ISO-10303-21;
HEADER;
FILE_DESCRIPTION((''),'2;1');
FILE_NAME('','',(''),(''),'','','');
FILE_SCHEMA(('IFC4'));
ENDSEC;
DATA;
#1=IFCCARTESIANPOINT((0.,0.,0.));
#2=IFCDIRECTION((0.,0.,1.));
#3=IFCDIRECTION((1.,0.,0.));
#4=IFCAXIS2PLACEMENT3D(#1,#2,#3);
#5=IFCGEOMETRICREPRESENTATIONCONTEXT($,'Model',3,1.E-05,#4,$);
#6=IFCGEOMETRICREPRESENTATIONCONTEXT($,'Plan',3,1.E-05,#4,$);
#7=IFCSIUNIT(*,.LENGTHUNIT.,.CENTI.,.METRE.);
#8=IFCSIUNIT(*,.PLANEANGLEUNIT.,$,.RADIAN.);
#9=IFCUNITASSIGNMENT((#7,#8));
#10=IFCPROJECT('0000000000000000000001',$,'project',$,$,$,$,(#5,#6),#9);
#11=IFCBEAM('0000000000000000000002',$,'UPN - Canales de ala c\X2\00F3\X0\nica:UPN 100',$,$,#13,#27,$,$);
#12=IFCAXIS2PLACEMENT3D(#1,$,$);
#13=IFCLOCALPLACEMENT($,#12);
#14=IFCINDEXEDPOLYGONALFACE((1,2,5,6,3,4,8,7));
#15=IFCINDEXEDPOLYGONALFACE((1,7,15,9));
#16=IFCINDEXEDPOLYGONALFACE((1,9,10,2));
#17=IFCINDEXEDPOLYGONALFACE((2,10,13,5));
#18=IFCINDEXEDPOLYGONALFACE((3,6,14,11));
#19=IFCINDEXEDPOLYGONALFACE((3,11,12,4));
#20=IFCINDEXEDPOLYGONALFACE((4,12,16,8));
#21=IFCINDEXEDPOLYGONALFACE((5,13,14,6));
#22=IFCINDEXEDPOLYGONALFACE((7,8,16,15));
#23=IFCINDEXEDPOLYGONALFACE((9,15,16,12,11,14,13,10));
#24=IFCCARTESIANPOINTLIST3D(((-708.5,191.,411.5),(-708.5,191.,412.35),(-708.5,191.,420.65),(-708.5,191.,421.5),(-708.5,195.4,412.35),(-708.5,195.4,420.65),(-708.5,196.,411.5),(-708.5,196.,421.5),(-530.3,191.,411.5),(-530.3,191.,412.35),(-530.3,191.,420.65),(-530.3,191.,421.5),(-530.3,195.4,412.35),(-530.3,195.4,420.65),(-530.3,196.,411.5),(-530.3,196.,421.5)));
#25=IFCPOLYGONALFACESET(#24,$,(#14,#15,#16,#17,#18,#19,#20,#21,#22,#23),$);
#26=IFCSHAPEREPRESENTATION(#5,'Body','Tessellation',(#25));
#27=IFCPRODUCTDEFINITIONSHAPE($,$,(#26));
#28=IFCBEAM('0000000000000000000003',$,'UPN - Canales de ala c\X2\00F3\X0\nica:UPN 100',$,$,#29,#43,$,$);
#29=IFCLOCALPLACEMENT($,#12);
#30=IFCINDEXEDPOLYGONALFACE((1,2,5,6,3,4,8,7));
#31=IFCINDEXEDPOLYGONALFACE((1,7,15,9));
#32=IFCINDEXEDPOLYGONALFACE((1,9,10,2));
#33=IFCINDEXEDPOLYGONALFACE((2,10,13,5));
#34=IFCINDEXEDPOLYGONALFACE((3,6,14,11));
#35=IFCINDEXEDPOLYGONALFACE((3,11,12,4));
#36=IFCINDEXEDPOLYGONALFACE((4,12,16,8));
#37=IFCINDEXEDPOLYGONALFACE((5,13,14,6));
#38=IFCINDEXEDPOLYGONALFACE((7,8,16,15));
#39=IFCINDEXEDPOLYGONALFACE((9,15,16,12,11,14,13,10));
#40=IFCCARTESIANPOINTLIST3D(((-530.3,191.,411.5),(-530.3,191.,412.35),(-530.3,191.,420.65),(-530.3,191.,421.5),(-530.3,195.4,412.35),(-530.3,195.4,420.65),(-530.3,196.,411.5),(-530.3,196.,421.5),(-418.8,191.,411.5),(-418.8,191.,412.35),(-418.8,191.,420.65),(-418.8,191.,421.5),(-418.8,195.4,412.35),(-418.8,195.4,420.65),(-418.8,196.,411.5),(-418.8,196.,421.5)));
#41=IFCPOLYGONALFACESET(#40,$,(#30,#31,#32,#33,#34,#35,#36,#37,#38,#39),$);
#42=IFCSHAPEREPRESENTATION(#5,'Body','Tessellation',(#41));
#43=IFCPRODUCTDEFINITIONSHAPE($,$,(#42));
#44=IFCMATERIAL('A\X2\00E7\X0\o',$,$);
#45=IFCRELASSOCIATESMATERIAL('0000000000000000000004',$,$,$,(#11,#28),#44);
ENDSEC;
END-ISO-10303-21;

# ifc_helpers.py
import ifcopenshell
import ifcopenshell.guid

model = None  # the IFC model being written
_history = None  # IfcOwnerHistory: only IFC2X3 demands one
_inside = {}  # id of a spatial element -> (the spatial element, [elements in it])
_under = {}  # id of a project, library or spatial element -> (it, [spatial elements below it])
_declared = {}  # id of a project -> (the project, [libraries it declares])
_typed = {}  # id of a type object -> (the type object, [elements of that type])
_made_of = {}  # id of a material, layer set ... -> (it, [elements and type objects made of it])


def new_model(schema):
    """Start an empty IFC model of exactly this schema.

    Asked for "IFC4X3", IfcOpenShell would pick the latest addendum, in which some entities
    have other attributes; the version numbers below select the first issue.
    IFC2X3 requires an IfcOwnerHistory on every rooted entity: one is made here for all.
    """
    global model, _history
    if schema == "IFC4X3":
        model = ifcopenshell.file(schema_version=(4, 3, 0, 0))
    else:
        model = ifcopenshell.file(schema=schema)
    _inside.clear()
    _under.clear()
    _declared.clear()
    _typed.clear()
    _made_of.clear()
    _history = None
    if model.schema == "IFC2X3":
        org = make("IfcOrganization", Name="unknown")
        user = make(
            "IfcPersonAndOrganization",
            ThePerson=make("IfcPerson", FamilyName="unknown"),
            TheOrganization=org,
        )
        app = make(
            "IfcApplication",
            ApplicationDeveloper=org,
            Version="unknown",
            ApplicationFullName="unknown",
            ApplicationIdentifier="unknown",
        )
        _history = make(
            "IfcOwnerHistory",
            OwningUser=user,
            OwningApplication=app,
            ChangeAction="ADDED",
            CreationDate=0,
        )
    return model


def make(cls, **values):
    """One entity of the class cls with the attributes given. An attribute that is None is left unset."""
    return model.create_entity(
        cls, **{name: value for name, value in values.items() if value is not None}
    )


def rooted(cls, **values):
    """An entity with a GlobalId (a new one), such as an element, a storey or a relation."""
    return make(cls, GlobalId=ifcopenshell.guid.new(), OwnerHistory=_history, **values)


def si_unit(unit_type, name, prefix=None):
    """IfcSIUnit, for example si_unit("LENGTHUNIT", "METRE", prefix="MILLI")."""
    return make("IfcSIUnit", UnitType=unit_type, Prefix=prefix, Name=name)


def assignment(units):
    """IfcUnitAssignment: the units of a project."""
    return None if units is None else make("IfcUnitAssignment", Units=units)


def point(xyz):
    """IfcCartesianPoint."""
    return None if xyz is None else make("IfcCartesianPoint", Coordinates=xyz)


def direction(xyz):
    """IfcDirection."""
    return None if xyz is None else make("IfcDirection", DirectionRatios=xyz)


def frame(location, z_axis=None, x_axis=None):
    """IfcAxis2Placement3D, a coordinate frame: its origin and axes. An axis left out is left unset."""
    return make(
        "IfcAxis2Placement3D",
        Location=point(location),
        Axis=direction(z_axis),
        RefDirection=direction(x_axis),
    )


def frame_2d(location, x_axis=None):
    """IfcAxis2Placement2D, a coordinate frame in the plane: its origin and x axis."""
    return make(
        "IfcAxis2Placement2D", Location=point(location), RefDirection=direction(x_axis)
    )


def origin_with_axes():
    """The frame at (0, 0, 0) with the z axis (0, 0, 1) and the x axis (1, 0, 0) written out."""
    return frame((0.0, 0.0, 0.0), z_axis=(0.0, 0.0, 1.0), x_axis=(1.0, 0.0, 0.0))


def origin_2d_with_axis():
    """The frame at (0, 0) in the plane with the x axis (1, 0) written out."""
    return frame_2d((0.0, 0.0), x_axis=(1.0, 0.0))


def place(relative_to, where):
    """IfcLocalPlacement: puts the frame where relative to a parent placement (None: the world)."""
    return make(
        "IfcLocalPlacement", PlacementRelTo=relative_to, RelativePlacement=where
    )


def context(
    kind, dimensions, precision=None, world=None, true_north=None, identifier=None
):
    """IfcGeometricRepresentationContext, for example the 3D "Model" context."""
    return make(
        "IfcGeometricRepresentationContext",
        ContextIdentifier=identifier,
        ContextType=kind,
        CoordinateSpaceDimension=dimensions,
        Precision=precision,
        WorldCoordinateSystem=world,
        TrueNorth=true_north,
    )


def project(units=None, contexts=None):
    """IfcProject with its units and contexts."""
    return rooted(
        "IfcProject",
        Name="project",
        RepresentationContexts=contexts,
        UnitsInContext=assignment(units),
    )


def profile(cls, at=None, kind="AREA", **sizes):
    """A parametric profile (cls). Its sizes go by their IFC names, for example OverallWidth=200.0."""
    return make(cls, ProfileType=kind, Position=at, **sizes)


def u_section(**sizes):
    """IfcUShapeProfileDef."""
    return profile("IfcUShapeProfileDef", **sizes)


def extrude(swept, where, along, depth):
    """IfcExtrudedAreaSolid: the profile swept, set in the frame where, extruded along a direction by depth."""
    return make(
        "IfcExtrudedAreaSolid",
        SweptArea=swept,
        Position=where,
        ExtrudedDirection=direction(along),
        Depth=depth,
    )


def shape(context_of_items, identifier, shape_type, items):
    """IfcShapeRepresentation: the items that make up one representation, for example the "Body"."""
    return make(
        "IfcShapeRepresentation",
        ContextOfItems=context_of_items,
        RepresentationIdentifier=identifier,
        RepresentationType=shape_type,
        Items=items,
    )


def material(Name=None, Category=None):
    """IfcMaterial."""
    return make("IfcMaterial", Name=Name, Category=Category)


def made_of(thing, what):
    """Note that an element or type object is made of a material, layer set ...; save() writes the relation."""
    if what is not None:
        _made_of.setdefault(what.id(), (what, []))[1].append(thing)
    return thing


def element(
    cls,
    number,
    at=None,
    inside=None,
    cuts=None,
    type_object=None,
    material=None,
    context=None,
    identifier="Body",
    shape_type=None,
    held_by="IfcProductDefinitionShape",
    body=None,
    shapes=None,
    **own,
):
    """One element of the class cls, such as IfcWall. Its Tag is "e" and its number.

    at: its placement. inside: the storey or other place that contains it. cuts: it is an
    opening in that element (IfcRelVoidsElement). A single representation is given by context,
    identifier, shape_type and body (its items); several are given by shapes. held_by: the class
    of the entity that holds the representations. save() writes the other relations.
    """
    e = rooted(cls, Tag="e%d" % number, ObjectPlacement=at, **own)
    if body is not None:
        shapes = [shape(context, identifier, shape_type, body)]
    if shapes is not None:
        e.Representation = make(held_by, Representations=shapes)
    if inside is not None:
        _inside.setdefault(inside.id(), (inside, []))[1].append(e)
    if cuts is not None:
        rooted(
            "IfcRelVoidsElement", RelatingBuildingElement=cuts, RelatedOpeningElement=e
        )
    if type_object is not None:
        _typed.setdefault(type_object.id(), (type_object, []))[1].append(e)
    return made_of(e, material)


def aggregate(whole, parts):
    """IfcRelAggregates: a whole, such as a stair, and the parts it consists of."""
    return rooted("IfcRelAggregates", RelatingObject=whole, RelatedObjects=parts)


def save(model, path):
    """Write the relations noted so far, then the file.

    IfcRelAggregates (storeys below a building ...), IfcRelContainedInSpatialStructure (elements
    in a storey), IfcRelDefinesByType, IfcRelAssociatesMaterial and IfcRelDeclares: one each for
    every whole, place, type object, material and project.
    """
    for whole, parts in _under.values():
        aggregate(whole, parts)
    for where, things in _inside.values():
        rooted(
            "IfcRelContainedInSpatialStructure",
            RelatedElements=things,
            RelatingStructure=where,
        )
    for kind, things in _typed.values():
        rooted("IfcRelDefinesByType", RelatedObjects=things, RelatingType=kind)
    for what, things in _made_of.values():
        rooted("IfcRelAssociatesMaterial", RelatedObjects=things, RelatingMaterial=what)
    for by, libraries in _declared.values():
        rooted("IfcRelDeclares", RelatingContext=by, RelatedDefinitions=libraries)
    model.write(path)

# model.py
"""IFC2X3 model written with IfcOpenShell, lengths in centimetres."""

from ifc_helpers import new_model, si_unit, frame, origin_with_axes, origin_2d_with_axis, place, context, project, u_section, extrude, material, element, save


model = new_model("IFC2X3")

# Units and contexts
model_context = context("Model", 3, precision=1e-05, world=origin_with_axes())
plan_context = context("Plan", 3, precision=1e-05, world=origin_with_axes())
ifc_project = project(units=[si_unit("LENGTHUNIT", "METRE", prefix="CENTI"), si_unit("PLANEANGLEUNIT", "RADIAN")], contexts=[model_context, plan_context])

# Shared definitions
ifc_material = material(Name="Aço")

# Beams
beam_1_placement = place(None, frame((-530.3, 193.5, 416.5), z_axis=(-1.0, 0.0, 0.0), x_axis=(0.0, -1.0, 0.0)))
element("IfcBeam", 1, at=beam_1_placement, material=ifc_material, Name="UPN - Canales de ala cónica:UPN 100", context=model_context, shape_type="SweptSolid", body=[
    extrude(u_section(Depth=10.0, FlangeWidth=5.0, WebThickness=0.6, FlangeThickness=0.85, FilletRadius=0.0, EdgeRadius=0.0, FlangeSlope=0.0, CentreOfGravityInX=0.0, at=origin_2d_with_axis()), origin_with_axes(), (0.0, 0.0, 1.0), 178.2),
])
beam_2_placement = place(None, frame((-418.8, 193.5, 416.5), z_axis=(-1.0, 0.0, 0.0), x_axis=(0.0, -1.0, 0.0)))
element("IfcBeam", 2, at=beam_2_placement, material=ifc_material, Name="UPN - Canales de ala cónica:UPN 100", context=model_context, shape_type="SweptSolid", body=[
    extrude(u_section(Depth=10.0, FlangeWidth=5.0, WebThickness=0.6, FlangeThickness=0.85, FilletRadius=0.0, EdgeRadius=0.0, FlangeSlope=0.0, CentreOfGravityInX=0.0, at=origin_2d_with_axis()), origin_with_axes(), (0.0, 0.0, 1.0), 111.5),
])

save(model, "model.ifc")
